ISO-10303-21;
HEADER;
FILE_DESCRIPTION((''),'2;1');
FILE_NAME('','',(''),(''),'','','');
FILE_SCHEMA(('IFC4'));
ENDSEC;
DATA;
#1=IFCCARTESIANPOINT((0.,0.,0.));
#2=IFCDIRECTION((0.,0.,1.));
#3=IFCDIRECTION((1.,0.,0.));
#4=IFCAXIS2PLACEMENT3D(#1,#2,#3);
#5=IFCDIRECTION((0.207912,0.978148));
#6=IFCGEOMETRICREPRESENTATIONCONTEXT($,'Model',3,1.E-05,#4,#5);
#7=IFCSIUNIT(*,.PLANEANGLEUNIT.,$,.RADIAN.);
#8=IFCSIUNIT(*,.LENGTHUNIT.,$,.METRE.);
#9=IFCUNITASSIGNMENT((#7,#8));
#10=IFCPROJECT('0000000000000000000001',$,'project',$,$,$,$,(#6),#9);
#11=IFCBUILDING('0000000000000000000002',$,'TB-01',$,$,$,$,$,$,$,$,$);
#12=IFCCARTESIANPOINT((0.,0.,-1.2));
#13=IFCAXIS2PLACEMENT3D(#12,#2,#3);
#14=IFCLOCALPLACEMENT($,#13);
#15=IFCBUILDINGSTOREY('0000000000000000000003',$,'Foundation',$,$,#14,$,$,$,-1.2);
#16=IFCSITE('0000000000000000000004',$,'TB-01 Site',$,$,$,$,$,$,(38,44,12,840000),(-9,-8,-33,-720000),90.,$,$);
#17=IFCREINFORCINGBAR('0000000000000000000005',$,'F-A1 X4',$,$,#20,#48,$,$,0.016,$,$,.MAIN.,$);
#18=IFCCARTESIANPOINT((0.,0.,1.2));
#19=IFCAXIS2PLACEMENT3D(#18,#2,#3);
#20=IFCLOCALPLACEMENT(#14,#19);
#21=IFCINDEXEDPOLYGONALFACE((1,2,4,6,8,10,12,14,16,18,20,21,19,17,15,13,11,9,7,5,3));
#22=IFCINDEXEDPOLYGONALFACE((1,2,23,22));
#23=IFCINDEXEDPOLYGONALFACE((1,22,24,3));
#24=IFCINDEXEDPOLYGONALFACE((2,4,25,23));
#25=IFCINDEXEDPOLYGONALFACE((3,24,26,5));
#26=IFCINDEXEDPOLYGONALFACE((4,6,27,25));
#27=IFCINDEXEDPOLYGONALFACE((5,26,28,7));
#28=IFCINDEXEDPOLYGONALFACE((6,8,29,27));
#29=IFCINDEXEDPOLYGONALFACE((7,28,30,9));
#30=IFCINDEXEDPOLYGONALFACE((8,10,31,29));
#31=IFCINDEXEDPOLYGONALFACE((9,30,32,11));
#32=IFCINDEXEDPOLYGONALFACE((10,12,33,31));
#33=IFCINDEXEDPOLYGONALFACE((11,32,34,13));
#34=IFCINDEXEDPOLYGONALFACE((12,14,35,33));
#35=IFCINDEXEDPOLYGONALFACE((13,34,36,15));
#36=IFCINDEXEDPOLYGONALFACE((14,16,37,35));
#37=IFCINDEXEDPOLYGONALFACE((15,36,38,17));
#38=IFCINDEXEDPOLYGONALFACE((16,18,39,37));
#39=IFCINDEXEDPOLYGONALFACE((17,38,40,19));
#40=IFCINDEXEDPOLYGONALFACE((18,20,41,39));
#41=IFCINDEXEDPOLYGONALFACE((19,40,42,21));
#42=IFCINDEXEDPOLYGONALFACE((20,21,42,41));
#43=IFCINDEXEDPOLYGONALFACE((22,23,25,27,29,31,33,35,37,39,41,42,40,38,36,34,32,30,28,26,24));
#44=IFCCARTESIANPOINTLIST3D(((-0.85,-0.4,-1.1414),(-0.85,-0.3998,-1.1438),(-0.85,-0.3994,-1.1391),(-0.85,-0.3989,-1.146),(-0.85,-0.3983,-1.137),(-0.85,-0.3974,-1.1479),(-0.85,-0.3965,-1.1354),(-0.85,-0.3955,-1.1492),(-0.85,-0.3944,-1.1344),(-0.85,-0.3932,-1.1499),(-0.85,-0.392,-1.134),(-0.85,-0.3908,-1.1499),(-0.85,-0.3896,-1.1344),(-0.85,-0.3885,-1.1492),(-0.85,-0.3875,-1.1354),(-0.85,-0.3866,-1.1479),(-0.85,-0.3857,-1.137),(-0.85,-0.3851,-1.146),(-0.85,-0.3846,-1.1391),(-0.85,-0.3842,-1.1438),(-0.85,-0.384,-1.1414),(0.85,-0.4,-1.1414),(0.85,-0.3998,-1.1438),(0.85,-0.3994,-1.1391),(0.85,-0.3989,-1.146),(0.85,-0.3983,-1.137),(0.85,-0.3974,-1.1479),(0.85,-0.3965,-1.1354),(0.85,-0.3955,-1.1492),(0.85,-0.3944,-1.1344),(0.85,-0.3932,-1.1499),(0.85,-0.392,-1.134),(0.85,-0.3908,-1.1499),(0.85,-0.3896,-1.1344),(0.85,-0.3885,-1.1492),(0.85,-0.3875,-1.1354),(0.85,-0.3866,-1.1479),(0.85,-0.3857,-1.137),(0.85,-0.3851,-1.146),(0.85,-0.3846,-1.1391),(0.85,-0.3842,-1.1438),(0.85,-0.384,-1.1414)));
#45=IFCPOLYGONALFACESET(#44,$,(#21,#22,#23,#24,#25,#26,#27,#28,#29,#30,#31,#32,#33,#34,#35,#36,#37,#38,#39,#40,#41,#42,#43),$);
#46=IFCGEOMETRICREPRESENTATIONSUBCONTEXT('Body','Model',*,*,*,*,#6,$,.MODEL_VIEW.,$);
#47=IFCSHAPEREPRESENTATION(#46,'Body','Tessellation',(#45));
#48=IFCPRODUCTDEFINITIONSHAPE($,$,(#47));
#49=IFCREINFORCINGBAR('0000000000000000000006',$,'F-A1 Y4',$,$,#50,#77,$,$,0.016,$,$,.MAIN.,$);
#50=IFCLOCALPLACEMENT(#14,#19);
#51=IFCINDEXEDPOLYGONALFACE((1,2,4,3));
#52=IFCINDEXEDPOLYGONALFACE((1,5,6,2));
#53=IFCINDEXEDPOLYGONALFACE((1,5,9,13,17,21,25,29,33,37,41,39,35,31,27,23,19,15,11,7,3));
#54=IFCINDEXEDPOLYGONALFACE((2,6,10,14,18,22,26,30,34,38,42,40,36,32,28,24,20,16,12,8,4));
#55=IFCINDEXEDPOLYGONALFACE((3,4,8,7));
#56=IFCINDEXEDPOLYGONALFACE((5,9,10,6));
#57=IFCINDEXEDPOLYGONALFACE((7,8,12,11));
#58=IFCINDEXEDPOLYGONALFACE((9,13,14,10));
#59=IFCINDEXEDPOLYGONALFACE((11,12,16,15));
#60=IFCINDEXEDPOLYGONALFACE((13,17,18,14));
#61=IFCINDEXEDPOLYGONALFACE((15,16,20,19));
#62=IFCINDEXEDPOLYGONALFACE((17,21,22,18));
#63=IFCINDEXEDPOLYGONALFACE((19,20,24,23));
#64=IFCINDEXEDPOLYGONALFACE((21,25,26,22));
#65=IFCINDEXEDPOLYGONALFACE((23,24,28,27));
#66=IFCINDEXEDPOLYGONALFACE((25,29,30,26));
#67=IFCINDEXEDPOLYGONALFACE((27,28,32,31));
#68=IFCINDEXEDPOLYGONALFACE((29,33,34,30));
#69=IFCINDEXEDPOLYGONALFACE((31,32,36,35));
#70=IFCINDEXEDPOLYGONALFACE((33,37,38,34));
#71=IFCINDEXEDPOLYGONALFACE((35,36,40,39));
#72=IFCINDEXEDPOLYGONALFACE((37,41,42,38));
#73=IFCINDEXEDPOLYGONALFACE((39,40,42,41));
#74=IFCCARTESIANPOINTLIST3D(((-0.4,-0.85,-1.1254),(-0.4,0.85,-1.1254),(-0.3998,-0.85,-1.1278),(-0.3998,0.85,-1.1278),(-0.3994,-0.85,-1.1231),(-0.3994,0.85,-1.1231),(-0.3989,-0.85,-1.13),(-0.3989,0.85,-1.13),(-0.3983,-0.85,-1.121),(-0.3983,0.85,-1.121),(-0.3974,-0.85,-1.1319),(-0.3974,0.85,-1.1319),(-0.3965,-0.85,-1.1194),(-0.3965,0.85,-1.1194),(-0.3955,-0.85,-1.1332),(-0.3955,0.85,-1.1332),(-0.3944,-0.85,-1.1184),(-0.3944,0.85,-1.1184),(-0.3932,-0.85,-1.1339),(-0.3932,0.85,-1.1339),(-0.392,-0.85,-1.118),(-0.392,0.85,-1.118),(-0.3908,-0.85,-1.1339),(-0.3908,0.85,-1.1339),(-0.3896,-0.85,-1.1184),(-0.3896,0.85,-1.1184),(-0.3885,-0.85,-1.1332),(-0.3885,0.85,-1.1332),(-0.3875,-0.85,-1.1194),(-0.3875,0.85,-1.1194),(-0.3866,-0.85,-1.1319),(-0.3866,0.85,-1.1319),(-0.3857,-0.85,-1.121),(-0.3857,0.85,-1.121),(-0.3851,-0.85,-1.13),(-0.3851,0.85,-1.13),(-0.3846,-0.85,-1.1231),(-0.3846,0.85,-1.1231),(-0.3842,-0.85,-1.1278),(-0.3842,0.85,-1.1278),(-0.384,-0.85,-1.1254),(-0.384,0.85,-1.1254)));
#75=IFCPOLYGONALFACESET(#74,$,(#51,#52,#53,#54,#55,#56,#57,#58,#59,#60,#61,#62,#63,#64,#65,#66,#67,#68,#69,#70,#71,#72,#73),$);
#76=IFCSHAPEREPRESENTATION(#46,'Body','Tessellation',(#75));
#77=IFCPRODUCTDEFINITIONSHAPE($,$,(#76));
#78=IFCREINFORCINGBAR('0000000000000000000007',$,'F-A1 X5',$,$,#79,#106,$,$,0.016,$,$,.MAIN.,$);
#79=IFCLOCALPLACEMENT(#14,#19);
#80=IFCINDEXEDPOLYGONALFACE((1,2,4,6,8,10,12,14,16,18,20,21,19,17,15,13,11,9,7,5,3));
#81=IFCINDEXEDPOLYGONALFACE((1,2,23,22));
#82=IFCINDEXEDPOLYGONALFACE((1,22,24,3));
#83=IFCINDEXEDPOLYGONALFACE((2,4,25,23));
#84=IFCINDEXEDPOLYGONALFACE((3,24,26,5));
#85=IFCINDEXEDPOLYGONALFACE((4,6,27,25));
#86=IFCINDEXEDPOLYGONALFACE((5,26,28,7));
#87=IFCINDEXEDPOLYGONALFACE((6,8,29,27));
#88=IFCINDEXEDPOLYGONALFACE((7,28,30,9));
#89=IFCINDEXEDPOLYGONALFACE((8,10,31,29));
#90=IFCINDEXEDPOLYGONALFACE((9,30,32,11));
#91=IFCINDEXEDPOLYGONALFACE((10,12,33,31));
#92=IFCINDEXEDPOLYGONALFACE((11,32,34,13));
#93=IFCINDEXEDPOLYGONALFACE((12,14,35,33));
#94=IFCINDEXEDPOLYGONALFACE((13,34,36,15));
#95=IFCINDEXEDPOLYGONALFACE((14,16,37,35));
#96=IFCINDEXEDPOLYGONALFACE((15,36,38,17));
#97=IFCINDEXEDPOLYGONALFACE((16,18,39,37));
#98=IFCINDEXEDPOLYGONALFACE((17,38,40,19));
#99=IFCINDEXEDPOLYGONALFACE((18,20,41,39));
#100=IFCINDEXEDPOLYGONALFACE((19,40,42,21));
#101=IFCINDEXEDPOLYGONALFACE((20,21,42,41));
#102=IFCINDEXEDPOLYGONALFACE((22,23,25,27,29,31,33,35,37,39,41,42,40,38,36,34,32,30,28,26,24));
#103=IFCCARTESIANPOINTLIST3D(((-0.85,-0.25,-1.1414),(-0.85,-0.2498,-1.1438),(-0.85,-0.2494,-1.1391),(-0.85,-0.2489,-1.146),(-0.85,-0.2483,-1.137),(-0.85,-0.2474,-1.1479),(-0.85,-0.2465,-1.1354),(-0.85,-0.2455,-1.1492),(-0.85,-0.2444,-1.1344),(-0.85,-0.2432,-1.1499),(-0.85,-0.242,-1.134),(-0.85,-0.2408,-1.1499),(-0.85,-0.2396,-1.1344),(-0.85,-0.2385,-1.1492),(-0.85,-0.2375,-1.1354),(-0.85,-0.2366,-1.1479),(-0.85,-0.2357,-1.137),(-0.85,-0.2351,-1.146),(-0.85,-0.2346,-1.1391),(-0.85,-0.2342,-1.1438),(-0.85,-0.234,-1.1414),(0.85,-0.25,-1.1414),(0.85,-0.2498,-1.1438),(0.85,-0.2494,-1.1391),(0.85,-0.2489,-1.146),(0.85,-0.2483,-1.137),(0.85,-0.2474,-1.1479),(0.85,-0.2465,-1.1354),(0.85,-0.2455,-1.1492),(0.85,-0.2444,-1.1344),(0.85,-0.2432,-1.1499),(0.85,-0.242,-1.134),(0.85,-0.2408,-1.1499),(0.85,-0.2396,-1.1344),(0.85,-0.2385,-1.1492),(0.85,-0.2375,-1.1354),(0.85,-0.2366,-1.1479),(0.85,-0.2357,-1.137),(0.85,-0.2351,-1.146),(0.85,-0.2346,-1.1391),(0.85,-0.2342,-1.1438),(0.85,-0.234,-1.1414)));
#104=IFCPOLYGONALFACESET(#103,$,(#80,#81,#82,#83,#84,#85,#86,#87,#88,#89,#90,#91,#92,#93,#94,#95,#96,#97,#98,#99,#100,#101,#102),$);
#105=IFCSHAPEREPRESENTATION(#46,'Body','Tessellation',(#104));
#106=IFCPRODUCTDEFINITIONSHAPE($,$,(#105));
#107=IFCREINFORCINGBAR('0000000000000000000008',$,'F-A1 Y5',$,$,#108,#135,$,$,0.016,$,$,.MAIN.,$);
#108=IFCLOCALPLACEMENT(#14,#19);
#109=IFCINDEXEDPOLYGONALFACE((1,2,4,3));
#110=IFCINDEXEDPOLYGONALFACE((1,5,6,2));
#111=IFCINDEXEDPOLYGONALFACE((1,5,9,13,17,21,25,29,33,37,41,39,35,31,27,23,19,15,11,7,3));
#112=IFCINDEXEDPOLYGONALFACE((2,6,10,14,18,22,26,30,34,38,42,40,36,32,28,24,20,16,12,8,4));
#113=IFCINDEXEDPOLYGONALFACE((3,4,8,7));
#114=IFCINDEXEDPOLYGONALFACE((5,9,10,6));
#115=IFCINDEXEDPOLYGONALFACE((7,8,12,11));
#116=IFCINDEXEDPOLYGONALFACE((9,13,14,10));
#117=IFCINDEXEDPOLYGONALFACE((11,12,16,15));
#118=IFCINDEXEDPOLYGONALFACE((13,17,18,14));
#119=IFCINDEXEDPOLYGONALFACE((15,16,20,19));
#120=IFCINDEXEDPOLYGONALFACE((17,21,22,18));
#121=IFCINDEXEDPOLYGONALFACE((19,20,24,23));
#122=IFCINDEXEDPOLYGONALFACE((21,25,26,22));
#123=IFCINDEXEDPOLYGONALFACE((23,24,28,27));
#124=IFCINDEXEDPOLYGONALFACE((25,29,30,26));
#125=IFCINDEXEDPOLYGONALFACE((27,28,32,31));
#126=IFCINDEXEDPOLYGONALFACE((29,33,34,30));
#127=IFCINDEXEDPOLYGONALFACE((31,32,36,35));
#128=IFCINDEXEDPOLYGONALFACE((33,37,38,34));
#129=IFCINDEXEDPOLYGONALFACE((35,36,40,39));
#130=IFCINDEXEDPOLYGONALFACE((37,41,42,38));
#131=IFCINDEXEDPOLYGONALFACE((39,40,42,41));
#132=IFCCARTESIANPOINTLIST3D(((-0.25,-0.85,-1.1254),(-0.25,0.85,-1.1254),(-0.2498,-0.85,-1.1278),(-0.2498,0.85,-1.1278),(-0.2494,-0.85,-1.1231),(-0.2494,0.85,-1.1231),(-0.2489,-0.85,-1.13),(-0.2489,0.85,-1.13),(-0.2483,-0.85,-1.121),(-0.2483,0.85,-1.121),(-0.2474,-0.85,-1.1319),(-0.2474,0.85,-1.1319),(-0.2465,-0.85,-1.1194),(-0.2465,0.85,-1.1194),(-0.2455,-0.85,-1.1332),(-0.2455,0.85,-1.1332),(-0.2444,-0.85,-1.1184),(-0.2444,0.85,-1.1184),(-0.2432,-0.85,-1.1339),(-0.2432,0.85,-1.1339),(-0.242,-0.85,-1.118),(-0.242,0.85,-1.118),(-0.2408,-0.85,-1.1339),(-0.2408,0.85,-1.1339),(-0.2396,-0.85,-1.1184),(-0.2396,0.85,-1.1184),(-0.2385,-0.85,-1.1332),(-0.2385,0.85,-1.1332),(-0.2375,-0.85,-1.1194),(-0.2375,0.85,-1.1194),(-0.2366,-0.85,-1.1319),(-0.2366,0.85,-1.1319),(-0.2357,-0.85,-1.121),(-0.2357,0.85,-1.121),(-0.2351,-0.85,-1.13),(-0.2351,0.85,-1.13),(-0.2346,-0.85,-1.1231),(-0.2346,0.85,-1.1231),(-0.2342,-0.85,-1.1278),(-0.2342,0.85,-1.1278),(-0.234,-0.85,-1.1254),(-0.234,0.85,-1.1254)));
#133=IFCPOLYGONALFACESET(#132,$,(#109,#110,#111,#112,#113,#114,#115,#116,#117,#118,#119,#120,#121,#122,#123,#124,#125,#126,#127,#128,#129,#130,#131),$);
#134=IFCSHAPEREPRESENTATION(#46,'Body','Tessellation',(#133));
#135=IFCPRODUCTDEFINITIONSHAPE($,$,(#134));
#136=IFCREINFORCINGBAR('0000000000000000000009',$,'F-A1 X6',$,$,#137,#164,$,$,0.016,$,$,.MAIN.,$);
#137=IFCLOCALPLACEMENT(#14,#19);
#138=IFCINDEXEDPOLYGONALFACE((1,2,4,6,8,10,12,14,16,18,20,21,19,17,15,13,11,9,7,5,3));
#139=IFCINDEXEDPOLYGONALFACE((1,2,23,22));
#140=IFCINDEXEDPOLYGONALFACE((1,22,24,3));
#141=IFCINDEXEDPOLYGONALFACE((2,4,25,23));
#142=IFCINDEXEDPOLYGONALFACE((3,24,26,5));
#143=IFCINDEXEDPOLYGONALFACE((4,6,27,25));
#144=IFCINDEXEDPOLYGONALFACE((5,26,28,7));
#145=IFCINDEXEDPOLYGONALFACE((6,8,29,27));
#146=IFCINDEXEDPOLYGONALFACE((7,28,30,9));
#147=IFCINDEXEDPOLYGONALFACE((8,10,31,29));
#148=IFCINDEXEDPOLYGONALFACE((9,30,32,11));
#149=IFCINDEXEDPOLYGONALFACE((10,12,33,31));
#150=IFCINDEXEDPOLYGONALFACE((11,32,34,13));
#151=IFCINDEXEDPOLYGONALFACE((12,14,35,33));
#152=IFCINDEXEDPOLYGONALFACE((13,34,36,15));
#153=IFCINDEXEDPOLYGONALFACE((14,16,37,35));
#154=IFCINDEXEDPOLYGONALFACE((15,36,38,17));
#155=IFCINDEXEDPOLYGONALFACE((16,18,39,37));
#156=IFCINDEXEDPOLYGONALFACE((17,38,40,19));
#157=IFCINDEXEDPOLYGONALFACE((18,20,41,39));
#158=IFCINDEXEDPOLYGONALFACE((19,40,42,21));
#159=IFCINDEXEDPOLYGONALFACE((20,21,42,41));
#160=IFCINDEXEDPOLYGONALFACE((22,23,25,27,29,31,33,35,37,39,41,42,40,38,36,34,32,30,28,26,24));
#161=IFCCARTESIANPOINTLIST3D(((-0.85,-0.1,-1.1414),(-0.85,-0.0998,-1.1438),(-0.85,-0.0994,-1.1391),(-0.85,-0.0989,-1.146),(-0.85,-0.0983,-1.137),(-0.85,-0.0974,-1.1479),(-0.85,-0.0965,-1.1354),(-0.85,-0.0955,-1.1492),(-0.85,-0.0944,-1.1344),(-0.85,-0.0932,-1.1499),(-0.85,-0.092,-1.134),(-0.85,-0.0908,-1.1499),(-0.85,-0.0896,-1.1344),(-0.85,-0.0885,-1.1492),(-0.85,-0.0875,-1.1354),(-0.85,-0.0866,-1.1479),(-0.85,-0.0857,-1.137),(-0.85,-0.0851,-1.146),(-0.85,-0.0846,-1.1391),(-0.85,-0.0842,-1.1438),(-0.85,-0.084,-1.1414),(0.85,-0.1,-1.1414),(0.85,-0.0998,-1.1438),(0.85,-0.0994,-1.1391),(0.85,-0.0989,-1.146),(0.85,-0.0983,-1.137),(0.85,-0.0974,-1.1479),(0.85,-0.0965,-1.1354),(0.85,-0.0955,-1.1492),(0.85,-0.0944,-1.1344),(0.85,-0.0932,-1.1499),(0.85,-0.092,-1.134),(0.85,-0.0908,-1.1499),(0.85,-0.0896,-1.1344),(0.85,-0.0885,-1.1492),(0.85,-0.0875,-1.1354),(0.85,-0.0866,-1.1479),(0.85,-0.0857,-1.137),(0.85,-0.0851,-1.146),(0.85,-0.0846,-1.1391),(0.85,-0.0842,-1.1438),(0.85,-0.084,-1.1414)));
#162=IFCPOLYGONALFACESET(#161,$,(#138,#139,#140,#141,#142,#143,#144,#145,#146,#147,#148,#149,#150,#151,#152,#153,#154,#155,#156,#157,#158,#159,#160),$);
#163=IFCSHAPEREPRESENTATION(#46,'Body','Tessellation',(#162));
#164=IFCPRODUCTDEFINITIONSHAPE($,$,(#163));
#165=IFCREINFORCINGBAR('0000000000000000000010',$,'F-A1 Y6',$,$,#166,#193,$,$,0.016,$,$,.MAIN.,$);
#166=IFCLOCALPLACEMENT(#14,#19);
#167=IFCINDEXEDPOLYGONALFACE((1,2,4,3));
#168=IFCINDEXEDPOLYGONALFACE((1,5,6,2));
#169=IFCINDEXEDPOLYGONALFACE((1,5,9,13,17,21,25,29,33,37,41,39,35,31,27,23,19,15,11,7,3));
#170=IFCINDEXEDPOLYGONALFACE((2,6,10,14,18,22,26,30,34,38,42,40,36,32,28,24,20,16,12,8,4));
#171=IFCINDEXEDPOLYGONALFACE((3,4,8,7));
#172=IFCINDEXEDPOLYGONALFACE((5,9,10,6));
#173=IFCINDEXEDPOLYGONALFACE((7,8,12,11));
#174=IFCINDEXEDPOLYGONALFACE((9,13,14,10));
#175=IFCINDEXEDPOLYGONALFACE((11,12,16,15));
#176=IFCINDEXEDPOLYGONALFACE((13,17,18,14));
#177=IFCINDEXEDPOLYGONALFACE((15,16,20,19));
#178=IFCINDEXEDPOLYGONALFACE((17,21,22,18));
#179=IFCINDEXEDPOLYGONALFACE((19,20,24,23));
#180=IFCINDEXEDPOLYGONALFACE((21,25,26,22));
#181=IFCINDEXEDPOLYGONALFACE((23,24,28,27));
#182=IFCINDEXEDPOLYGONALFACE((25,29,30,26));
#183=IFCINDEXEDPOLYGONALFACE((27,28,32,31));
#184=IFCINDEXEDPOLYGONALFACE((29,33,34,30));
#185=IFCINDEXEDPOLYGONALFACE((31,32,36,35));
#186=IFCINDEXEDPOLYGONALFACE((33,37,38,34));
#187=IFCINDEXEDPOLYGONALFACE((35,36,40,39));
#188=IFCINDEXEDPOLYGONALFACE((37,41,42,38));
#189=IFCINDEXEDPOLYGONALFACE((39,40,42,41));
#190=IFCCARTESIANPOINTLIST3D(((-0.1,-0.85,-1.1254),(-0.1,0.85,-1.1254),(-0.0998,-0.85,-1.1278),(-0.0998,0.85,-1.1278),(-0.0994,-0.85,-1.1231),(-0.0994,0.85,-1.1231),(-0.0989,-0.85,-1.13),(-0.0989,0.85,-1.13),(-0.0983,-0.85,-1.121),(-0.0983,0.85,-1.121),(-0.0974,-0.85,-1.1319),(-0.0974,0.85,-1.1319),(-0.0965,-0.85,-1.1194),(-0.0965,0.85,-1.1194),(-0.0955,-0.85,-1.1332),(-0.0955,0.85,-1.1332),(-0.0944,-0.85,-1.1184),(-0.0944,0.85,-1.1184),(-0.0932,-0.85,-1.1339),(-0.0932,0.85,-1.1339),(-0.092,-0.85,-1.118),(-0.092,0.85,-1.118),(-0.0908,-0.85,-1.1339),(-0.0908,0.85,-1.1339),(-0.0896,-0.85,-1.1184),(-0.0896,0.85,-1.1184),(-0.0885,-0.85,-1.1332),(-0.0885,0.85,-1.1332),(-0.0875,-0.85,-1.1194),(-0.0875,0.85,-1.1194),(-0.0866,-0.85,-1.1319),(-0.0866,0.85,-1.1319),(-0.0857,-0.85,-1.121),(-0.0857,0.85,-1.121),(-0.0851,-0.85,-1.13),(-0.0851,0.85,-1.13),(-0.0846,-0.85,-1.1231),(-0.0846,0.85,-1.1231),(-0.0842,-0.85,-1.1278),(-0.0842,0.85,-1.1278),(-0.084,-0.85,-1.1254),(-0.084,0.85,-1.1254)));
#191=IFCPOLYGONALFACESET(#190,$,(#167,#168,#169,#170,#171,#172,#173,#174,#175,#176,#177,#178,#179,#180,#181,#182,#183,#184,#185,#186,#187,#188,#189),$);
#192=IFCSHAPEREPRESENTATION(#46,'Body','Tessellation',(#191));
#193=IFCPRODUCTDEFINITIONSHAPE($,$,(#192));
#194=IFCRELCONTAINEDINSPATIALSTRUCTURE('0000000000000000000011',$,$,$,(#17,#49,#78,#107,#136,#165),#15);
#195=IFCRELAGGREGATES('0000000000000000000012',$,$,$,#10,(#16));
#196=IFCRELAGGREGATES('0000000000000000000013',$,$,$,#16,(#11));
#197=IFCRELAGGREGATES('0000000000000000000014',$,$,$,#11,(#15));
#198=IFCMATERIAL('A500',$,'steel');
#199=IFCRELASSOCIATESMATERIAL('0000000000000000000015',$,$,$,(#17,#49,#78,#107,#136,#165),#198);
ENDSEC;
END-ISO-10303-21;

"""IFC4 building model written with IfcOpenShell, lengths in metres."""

from ifc_helpers import new_model, entity, si_unit, direction, frame, origin_with_axes, place, context, subcontext, project, spatial, material, element, save


model = new_model("IFC4")

# Units and contexts
model_context = context("Model", 3, precision=1e-05, world=origin_with_axes(), true_north=direction((0.207912, 0.978148)))
body_context = subcontext(model_context, "Body", "Model", "MODEL_VIEW")
ifc_project = project(units=[si_unit("PLANEANGLEUNIT", "RADIAN"), si_unit("LENGTHUNIT", "METRE")], contexts=[model_context])

# Site, building, storey
site = spatial("IfcSite", under=ifc_project, Name="TB-01 Site", RefLatitude=(38, 44, 12, 840000), RefLongitude=(-9, -8, -33, -720000), RefElevation=90.0)
building = spatial("IfcBuilding", under=site, Name="TB-01")
storey_placement = place(None, frame((0.0, 0.0, -1.2), z_axis=(0.0, 0.0, 1.0), x_axis=(1.0, 0.0, 0.0)))
storey = spatial("IfcBuildingStorey", under=building, at=storey_placement, Name="Foundation", Elevation=-1.2)

# Reinforcing bars
ifc_material_1 = material(Name="A500", Category="steel")
reinforcing_bar_1_placement = place(storey_placement, frame((0.0, 0.0, 1.2), z_axis=(0.0, 0.0, 1.0), x_axis=(1.0, 0.0, 0.0)))
element("IfcReinforcingBar", 1, at=reinforcing_bar_1_placement, inside=storey, material=ifc_material_1, Name="F-A1 X4", NominalDiameter=0.016, PredefinedType="MAIN", context=body_context, shape_type="AdvancedSweptSolid", body=[
    entity("IfcSweptDiskSolid", entity("IfcPolyline", [entity("IfcCartesianPoint", [-0.85, -0.392, -1.142]), entity("IfcCartesianPoint", [0.85, -0.392, -1.142])]), 0.008),
])
reinforcing_bar_2_placement = place(storey_placement, frame((0.0, 0.0, 1.2), z_axis=(0.0, 0.0, 1.0), x_axis=(1.0, 0.0, 0.0)))
element("IfcReinforcingBar", 2, at=reinforcing_bar_2_placement, inside=storey, material=ifc_material_1, Name="F-A1 Y4", NominalDiameter=0.016, PredefinedType="MAIN", context=body_context, shape_type="AdvancedSweptSolid", body=[
    entity("IfcSweptDiskSolid", entity("IfcPolyline", [entity("IfcCartesianPoint", [-0.392, -0.85, -1.126]), entity("IfcCartesianPoint", [-0.392, 0.85, -1.126])]), 0.008),
])
reinforcing_bar_3_placement = place(storey_placement, frame((0.0, 0.0, 1.2), z_axis=(0.0, 0.0, 1.0), x_axis=(1.0, 0.0, 0.0)))
element("IfcReinforcingBar", 3, at=reinforcing_bar_3_placement, inside=storey, material=ifc_material_1, Name="F-A1 X5", NominalDiameter=0.016, PredefinedType="MAIN", context=body_context, shape_type="AdvancedSweptSolid", body=[
    entity("IfcSweptDiskSolid", entity("IfcPolyline", [entity("IfcCartesianPoint", [-0.85, -0.242, -1.142]), entity("IfcCartesianPoint", [0.85, -0.242, -1.142])]), 0.008),
])
reinforcing_bar_4_placement = place(storey_placement, frame((0.0, 0.0, 1.2), z_axis=(0.0, 0.0, 1.0), x_axis=(1.0, 0.0, 0.0)))
element("IfcReinforcingBar", 4, at=reinforcing_bar_4_placement, inside=storey, material=ifc_material_1, Name="F-A1 Y5", NominalDiameter=0.016, PredefinedType="MAIN", context=body_context, shape_type="AdvancedSweptSolid", body=[
    entity("IfcSweptDiskSolid", entity("IfcPolyline", [entity("IfcCartesianPoint", [-0.242, -0.85, -1.126]), entity("IfcCartesianPoint", [-0.242, 0.85, -1.126])]), 0.008),
])
reinforcing_bar_5_placement = place(storey_placement, frame((0.0, 0.0, 1.2), z_axis=(0.0, 0.0, 1.0), x_axis=(1.0, 0.0, 0.0)))
element("IfcReinforcingBar", 5, at=reinforcing_bar_5_placement, inside=storey, material=ifc_material_1, Name="F-A1 X6", NominalDiameter=0.016, PredefinedType="MAIN", context=body_context, shape_type="AdvancedSweptSolid", body=[
    entity("IfcSweptDiskSolid", entity("IfcPolyline", [entity("IfcCartesianPoint", [-0.85, -0.092, -1.142]), entity("IfcCartesianPoint", [0.85, -0.092, -1.142])]), 0.008),
])
reinforcing_bar_6_placement = place(storey_placement, frame((0.0, 0.0, 1.2), z_axis=(0.0, 0.0, 1.0), x_axis=(1.0, 0.0, 0.0)))
element("IfcReinforcingBar", 6, at=reinforcing_bar_6_placement, inside=storey, material=ifc_material_1, Name="F-A1 Y6", NominalDiameter=0.016, PredefinedType="MAIN", context=body_context, shape_type="AdvancedSweptSolid", body=[
    entity("IfcSweptDiskSolid", entity("IfcPolyline", [entity("IfcCartesianPoint", [-0.092, -0.85, -1.126]), entity("IfcCartesianPoint", [-0.092, 0.85, -1.126])]), 0.008),
])

save(model, "model.ifc")
